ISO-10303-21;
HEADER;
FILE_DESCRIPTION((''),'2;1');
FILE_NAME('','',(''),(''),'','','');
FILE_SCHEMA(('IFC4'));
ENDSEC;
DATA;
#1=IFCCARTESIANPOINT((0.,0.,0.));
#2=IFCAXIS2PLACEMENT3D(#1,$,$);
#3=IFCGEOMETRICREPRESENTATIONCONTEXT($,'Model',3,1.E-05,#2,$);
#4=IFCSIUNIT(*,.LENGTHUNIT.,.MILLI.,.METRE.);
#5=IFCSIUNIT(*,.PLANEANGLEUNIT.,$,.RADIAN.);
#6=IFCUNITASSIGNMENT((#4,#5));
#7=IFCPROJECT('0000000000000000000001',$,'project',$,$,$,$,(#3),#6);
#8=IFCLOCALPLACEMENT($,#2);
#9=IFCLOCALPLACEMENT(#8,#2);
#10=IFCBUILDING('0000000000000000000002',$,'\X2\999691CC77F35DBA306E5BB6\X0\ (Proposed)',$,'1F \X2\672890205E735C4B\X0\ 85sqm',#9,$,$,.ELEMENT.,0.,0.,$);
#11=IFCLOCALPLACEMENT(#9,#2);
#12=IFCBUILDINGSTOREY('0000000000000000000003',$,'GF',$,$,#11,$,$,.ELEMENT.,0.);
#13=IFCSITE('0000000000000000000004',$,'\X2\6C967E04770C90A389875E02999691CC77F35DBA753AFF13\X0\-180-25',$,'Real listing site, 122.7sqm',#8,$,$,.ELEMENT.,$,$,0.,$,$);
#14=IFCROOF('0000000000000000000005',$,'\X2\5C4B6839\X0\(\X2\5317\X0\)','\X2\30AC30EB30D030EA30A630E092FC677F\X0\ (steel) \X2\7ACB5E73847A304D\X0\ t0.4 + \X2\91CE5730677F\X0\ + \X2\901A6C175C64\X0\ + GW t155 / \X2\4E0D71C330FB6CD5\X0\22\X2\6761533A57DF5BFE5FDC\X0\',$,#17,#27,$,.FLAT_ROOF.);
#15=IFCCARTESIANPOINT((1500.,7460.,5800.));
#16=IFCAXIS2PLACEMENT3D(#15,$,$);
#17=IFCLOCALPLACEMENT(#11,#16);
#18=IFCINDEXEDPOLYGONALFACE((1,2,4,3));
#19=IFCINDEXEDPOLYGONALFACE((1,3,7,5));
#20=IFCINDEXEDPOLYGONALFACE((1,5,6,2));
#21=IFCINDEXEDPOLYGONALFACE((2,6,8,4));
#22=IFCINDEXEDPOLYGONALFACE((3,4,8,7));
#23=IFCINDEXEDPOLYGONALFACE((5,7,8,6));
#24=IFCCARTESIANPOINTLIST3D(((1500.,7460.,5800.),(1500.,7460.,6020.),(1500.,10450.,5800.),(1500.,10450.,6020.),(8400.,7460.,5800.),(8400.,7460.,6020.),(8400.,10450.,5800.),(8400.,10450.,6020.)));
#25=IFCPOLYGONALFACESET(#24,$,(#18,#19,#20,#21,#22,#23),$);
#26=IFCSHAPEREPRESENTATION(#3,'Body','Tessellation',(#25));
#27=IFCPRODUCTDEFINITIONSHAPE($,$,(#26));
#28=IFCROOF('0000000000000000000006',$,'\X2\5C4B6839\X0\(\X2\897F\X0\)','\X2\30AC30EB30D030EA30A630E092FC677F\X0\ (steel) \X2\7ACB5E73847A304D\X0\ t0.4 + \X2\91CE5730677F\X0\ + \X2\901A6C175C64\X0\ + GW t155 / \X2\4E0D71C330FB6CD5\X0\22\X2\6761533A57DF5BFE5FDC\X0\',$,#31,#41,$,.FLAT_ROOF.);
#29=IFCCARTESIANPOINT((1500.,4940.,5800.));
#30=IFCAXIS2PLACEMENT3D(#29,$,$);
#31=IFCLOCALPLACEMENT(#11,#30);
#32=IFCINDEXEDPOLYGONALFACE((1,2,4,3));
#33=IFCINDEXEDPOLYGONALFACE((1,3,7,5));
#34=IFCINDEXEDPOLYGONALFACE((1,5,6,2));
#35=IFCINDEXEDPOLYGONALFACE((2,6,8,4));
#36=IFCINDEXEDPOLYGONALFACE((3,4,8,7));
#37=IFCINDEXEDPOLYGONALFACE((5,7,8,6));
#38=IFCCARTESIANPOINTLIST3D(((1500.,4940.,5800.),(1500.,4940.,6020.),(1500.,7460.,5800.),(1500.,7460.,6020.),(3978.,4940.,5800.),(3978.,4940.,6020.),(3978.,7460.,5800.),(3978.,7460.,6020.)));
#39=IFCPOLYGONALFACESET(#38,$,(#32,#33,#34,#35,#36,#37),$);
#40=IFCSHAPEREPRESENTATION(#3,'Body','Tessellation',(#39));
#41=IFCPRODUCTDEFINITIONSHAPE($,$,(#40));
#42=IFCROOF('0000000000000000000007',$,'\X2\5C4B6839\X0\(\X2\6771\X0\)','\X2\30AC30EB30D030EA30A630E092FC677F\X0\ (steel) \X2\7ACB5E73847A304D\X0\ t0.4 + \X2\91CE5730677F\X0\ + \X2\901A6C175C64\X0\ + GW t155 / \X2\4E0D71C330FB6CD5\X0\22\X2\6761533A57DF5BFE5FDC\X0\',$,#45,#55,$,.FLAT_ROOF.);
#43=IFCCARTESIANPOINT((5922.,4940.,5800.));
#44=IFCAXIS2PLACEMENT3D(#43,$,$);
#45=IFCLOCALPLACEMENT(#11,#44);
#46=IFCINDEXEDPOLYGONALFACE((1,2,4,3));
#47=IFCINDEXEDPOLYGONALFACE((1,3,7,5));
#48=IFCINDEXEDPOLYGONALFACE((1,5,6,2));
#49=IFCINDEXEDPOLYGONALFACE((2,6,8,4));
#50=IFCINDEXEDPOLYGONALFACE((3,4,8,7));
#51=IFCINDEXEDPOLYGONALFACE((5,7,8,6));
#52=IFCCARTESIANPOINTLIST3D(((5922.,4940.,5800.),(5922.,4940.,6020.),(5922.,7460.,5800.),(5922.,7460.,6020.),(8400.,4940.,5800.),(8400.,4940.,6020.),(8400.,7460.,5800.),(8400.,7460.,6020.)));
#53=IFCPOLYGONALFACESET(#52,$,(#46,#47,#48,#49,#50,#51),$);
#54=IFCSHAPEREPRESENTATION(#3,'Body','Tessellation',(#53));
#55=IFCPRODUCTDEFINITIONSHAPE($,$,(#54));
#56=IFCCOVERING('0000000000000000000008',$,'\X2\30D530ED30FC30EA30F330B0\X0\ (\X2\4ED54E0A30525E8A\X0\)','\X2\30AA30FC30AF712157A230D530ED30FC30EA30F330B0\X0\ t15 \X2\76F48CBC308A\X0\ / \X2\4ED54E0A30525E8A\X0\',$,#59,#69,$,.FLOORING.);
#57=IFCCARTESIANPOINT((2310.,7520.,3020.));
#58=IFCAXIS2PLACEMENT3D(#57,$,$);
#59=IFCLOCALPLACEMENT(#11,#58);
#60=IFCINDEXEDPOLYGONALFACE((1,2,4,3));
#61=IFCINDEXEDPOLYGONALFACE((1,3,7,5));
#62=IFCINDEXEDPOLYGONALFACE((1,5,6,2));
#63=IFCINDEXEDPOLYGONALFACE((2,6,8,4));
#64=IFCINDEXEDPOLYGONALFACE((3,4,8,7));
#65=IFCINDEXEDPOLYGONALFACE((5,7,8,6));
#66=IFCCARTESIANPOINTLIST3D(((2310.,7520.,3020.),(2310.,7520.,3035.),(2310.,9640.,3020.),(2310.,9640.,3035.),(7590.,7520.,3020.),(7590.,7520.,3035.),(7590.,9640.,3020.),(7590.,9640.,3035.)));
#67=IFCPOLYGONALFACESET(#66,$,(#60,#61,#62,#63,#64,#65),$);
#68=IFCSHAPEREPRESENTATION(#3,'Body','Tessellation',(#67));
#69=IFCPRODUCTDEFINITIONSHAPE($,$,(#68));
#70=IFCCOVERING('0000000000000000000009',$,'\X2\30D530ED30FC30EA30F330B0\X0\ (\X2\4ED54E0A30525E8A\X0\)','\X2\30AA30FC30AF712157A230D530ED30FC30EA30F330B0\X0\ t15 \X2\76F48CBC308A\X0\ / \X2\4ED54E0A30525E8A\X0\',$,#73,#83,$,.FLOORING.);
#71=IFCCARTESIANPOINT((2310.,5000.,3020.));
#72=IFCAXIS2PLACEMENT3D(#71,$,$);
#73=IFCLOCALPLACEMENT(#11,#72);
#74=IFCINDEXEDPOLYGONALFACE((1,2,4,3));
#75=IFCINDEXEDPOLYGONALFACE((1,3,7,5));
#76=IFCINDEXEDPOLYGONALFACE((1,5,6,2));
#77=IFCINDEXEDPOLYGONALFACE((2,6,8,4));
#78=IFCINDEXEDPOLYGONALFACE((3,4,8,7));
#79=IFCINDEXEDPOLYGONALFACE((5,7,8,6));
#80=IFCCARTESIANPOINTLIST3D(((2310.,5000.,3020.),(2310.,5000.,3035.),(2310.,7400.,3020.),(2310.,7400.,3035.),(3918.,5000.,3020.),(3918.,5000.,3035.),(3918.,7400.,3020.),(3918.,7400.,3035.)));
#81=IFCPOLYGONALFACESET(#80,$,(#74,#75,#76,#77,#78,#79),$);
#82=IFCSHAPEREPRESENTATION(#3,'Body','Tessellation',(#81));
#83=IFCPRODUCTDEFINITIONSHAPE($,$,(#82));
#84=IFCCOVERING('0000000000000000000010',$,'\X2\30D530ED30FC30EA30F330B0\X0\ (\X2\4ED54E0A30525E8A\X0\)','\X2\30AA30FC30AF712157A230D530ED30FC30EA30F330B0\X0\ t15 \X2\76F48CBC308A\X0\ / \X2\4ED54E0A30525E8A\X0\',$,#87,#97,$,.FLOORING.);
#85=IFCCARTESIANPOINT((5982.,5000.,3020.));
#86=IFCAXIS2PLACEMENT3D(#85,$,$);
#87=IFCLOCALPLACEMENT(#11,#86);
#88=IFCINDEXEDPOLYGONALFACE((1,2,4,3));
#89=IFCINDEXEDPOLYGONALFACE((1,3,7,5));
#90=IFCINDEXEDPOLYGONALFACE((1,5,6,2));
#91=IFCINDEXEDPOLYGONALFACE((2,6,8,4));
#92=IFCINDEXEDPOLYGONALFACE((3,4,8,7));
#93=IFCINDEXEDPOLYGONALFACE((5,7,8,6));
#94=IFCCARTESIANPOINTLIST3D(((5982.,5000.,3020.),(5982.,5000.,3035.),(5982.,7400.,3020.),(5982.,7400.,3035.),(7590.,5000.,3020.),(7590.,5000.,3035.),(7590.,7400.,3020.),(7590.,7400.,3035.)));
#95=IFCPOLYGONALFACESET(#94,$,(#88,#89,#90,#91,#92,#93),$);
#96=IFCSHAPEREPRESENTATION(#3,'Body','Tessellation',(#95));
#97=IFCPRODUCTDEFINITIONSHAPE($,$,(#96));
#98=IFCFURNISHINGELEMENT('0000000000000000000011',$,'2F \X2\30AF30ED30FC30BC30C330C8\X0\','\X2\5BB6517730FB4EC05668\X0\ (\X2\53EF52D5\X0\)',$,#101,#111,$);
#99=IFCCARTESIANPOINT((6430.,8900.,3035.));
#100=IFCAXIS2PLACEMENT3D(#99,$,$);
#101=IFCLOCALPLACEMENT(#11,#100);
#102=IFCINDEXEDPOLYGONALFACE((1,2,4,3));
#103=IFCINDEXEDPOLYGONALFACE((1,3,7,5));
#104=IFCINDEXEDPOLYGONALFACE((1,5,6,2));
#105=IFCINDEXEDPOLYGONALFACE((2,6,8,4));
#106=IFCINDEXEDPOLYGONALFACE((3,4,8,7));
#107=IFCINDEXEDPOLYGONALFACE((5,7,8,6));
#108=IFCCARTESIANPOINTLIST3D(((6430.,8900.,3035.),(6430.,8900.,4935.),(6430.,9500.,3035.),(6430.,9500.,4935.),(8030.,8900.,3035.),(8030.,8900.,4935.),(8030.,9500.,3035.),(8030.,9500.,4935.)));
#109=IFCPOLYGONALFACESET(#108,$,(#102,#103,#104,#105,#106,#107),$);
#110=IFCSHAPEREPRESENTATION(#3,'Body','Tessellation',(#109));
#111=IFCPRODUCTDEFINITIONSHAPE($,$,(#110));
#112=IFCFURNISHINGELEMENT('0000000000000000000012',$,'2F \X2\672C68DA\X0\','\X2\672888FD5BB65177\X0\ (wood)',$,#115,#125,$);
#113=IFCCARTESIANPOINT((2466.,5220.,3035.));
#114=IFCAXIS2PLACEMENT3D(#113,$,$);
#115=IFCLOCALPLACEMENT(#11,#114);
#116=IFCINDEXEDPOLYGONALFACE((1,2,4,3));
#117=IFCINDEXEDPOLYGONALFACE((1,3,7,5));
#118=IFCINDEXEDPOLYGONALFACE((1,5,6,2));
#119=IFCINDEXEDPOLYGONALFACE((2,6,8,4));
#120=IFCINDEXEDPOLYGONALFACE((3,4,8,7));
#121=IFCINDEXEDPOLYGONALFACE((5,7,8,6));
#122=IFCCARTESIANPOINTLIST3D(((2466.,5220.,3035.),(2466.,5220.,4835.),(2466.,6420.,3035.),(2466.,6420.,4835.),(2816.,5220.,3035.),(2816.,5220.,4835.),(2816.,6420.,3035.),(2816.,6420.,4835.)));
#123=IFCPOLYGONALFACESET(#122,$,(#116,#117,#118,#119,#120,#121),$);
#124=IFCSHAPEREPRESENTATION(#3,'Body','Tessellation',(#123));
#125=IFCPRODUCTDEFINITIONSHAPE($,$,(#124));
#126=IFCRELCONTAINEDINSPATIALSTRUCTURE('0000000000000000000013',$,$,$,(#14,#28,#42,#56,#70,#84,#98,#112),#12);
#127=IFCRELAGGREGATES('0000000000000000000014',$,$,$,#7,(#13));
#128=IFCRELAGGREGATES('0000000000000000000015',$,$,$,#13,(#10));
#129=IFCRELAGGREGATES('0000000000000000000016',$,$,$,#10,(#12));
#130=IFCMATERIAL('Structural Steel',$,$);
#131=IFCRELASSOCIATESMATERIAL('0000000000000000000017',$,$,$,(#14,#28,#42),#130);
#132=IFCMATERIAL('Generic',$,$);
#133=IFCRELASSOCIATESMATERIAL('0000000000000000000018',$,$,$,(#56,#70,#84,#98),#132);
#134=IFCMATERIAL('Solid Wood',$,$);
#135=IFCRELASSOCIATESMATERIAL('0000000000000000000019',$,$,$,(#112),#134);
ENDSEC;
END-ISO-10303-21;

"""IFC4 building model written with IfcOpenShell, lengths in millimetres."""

from ifc_helpers import new_model, si_unit, frame, frame_2d, origin, place, context, project, spatial, rectangle, extrude, material, element, save


model = new_model("IFC4")

# Units and contexts
model_context = context("Model", 3, precision=1e-05, world=origin())
ifc_project = project(units=[si_unit("LENGTHUNIT", "METRE", prefix="MILLI"), si_unit("PLANEANGLEUNIT", "RADIAN")], contexts=[model_context])

# Site, building, storey
site_placement = place(None, origin())
site = spatial("IfcSite", under=ifc_project, at=site_placement, Name="沖縄県那覇市首里石嶺町３-180-25", ObjectType="Real listing site, 122.7sqm", CompositionType="ELEMENT", RefElevation=0.0)
building_placement = place(site_placement, origin())
building = spatial("IfcBuilding", under=site, at=building_placement, Name="首里石嶺の家 (Proposed)", ObjectType="1F 木造平屋 85sqm", CompositionType="ELEMENT", ElevationOfRefHeight=0.0, ElevationOfTerrain=0.0)
storey_placement = place(building_placement, origin())
storey = spatial("IfcBuildingStorey", under=building, at=storey_placement, Name="GF", CompositionType="ELEMENT", Elevation=0.0)

# Shared definitions
ifc_material_1 = material(Name="Solid Wood")

# Shared definitions
ifc_material_2 = material(Name="Generic")

# Roofs
ifc_material_3 = material(Name="Structural Steel")
for number, where, name in (
    (1, (1500.0, 7460.0, 5800.0), "屋根(北)"),
):
    element("IfcRoof", number, at=place(storey_placement, frame(where)), inside=storey, material=ifc_material_3, Name=name, Description="ガルバリウム鋼板 (steel) 立平葺き t0.4 + 野地板 + 通気層 + GW t155 / 不燃・法22条区域対応", PredefinedType="FLAT_ROOF", context=model_context, shape_type="SweptSolid", body=[
        extrude(rectangle(XDim=6900.0, YDim=2990.0, at=frame_2d((3450.0, 1495.0))), frame((1500.0, 7460.0, 5800.0)), (0.0, 0.0, 1.0), 220.0),
    ])
roof_1_placement = place(storey_placement, frame((1500.0, 4940.0, 5800.0)))
element("IfcRoof", 2, at=roof_1_placement, inside=storey, material=ifc_material_3, Name="屋根(西)", Description="ガルバリウム鋼板 (steel) 立平葺き t0.4 + 野地板 + 通気層 + GW t155 / 不燃・法22条区域対応", PredefinedType="FLAT_ROOF", context=model_context, shape_type="SweptSolid", body=[
    extrude(rectangle(XDim=2478.0, YDim=2520.0, at=frame_2d((1239.0, 1260.0))), frame((1500.0, 4940.0, 5800.0)), (0.0, 0.0, 1.0), 220.0),
])
roof_2_placement = place(storey_placement, frame((5922.0, 4940.0, 5800.0)))
element("IfcRoof", 3, at=roof_2_placement, inside=storey, material=ifc_material_3, Name="屋根(東)", Description="ガルバリウム鋼板 (steel) 立平葺き t0.4 + 野地板 + 通気層 + GW t155 / 不燃・法22条区域対応", PredefinedType="FLAT_ROOF", context=model_context, shape_type="SweptSolid", body=[
    extrude(rectangle(XDim=2478.0, YDim=2520.0, at=frame_2d((1239.0, 1260.0))), frame((5922.0, 4940.0, 5800.0)), (0.0, 0.0, 1.0), 220.0),
])

# Coverings
covering_1_placement = place(storey_placement, frame((2310.0, 7520.0, 3020.0)))
element("IfcCovering", 4, at=covering_1_placement, inside=storey, material=ifc_material_2, Name="フローリング (仕上げ床)", Description="オーク無垢フローリング t15 直貼り / 仕上げ床", PredefinedType="FLOORING", context=model_context, shape_type="SweptSolid", body=[
    extrude(rectangle(XDim=5280.0, YDim=2120.0, at=frame_2d((2640.0, 1060.0))), frame((2310.0, 7520.0, 3020.0)), (0.0, 0.0, 1.0), 15.0),
])
covering_2_placement = place(storey_placement, frame((2310.0, 5000.0, 3020.0)))
element("IfcCovering", 5, at=covering_2_placement, inside=storey, material=ifc_material_2, Name="フローリング (仕上げ床)", Description="オーク無垢フローリング t15 直貼り / 仕上げ床", PredefinedType="FLOORING", context=model_context, shape_type="SweptSolid", body=[
    extrude(rectangle(XDim=1608.0, YDim=2400.0, at=frame_2d((804.0, 1200.0))), frame((2310.0, 5000.0, 3020.0)), (0.0, 0.0, 1.0), 15.0),
])
covering_3_placement = place(storey_placement, frame((5982.0, 5000.0, 3020.0)))
element("IfcCovering", 6, at=covering_3_placement, inside=storey, material=ifc_material_2, Name="フローリング (仕上げ床)", Description="オーク無垢フローリング t15 直貼り / 仕上げ床", PredefinedType="FLOORING", context=model_context, shape_type="SweptSolid", body=[
    extrude(rectangle(XDim=1608.0, YDim=2400.0, at=frame_2d((804.0, 1200.0))), frame((5982.0, 5000.0, 3020.0)), (0.0, 0.0, 1.0), 15.0),
])

# Furnishing elements
furnishing_1_placement = place(storey_placement, frame((6430.0, 8900.0, 3035.0)))
element("IfcFurnishingElement", 7, at=furnishing_1_placement, inside=storey, material=ifc_material_2, Name="2F クローゼット", Description="家具・什器 (可動)", context=model_context, shape_type="SweptSolid", body=[
    extrude(rectangle(XDim=1600.0, YDim=600.0, at=frame_2d((800.0, 300.0))), frame((6430.0, 8900.0, 3035.0)), (0.0, 0.0, 1.0), 1900.0),
])
furnishing_2_placement = place(storey_placement, frame((2466.0, 5220.0, 3035.0)))
element("IfcFurnishingElement", 8, at=furnishing_2_placement, inside=storey, material=ifc_material_1, Name="2F 本棚", Description="木製家具 (wood)", context=model_context, shape_type="SweptSolid", body=[
    extrude(rectangle(XDim=350.0, YDim=1200.0, at=frame_2d((175.0, 600.0))), frame((2466.0, 5220.0, 3035.0)), (0.0, 0.0, 1.0), 1800.0),
])

save(model, "model.ifc")
